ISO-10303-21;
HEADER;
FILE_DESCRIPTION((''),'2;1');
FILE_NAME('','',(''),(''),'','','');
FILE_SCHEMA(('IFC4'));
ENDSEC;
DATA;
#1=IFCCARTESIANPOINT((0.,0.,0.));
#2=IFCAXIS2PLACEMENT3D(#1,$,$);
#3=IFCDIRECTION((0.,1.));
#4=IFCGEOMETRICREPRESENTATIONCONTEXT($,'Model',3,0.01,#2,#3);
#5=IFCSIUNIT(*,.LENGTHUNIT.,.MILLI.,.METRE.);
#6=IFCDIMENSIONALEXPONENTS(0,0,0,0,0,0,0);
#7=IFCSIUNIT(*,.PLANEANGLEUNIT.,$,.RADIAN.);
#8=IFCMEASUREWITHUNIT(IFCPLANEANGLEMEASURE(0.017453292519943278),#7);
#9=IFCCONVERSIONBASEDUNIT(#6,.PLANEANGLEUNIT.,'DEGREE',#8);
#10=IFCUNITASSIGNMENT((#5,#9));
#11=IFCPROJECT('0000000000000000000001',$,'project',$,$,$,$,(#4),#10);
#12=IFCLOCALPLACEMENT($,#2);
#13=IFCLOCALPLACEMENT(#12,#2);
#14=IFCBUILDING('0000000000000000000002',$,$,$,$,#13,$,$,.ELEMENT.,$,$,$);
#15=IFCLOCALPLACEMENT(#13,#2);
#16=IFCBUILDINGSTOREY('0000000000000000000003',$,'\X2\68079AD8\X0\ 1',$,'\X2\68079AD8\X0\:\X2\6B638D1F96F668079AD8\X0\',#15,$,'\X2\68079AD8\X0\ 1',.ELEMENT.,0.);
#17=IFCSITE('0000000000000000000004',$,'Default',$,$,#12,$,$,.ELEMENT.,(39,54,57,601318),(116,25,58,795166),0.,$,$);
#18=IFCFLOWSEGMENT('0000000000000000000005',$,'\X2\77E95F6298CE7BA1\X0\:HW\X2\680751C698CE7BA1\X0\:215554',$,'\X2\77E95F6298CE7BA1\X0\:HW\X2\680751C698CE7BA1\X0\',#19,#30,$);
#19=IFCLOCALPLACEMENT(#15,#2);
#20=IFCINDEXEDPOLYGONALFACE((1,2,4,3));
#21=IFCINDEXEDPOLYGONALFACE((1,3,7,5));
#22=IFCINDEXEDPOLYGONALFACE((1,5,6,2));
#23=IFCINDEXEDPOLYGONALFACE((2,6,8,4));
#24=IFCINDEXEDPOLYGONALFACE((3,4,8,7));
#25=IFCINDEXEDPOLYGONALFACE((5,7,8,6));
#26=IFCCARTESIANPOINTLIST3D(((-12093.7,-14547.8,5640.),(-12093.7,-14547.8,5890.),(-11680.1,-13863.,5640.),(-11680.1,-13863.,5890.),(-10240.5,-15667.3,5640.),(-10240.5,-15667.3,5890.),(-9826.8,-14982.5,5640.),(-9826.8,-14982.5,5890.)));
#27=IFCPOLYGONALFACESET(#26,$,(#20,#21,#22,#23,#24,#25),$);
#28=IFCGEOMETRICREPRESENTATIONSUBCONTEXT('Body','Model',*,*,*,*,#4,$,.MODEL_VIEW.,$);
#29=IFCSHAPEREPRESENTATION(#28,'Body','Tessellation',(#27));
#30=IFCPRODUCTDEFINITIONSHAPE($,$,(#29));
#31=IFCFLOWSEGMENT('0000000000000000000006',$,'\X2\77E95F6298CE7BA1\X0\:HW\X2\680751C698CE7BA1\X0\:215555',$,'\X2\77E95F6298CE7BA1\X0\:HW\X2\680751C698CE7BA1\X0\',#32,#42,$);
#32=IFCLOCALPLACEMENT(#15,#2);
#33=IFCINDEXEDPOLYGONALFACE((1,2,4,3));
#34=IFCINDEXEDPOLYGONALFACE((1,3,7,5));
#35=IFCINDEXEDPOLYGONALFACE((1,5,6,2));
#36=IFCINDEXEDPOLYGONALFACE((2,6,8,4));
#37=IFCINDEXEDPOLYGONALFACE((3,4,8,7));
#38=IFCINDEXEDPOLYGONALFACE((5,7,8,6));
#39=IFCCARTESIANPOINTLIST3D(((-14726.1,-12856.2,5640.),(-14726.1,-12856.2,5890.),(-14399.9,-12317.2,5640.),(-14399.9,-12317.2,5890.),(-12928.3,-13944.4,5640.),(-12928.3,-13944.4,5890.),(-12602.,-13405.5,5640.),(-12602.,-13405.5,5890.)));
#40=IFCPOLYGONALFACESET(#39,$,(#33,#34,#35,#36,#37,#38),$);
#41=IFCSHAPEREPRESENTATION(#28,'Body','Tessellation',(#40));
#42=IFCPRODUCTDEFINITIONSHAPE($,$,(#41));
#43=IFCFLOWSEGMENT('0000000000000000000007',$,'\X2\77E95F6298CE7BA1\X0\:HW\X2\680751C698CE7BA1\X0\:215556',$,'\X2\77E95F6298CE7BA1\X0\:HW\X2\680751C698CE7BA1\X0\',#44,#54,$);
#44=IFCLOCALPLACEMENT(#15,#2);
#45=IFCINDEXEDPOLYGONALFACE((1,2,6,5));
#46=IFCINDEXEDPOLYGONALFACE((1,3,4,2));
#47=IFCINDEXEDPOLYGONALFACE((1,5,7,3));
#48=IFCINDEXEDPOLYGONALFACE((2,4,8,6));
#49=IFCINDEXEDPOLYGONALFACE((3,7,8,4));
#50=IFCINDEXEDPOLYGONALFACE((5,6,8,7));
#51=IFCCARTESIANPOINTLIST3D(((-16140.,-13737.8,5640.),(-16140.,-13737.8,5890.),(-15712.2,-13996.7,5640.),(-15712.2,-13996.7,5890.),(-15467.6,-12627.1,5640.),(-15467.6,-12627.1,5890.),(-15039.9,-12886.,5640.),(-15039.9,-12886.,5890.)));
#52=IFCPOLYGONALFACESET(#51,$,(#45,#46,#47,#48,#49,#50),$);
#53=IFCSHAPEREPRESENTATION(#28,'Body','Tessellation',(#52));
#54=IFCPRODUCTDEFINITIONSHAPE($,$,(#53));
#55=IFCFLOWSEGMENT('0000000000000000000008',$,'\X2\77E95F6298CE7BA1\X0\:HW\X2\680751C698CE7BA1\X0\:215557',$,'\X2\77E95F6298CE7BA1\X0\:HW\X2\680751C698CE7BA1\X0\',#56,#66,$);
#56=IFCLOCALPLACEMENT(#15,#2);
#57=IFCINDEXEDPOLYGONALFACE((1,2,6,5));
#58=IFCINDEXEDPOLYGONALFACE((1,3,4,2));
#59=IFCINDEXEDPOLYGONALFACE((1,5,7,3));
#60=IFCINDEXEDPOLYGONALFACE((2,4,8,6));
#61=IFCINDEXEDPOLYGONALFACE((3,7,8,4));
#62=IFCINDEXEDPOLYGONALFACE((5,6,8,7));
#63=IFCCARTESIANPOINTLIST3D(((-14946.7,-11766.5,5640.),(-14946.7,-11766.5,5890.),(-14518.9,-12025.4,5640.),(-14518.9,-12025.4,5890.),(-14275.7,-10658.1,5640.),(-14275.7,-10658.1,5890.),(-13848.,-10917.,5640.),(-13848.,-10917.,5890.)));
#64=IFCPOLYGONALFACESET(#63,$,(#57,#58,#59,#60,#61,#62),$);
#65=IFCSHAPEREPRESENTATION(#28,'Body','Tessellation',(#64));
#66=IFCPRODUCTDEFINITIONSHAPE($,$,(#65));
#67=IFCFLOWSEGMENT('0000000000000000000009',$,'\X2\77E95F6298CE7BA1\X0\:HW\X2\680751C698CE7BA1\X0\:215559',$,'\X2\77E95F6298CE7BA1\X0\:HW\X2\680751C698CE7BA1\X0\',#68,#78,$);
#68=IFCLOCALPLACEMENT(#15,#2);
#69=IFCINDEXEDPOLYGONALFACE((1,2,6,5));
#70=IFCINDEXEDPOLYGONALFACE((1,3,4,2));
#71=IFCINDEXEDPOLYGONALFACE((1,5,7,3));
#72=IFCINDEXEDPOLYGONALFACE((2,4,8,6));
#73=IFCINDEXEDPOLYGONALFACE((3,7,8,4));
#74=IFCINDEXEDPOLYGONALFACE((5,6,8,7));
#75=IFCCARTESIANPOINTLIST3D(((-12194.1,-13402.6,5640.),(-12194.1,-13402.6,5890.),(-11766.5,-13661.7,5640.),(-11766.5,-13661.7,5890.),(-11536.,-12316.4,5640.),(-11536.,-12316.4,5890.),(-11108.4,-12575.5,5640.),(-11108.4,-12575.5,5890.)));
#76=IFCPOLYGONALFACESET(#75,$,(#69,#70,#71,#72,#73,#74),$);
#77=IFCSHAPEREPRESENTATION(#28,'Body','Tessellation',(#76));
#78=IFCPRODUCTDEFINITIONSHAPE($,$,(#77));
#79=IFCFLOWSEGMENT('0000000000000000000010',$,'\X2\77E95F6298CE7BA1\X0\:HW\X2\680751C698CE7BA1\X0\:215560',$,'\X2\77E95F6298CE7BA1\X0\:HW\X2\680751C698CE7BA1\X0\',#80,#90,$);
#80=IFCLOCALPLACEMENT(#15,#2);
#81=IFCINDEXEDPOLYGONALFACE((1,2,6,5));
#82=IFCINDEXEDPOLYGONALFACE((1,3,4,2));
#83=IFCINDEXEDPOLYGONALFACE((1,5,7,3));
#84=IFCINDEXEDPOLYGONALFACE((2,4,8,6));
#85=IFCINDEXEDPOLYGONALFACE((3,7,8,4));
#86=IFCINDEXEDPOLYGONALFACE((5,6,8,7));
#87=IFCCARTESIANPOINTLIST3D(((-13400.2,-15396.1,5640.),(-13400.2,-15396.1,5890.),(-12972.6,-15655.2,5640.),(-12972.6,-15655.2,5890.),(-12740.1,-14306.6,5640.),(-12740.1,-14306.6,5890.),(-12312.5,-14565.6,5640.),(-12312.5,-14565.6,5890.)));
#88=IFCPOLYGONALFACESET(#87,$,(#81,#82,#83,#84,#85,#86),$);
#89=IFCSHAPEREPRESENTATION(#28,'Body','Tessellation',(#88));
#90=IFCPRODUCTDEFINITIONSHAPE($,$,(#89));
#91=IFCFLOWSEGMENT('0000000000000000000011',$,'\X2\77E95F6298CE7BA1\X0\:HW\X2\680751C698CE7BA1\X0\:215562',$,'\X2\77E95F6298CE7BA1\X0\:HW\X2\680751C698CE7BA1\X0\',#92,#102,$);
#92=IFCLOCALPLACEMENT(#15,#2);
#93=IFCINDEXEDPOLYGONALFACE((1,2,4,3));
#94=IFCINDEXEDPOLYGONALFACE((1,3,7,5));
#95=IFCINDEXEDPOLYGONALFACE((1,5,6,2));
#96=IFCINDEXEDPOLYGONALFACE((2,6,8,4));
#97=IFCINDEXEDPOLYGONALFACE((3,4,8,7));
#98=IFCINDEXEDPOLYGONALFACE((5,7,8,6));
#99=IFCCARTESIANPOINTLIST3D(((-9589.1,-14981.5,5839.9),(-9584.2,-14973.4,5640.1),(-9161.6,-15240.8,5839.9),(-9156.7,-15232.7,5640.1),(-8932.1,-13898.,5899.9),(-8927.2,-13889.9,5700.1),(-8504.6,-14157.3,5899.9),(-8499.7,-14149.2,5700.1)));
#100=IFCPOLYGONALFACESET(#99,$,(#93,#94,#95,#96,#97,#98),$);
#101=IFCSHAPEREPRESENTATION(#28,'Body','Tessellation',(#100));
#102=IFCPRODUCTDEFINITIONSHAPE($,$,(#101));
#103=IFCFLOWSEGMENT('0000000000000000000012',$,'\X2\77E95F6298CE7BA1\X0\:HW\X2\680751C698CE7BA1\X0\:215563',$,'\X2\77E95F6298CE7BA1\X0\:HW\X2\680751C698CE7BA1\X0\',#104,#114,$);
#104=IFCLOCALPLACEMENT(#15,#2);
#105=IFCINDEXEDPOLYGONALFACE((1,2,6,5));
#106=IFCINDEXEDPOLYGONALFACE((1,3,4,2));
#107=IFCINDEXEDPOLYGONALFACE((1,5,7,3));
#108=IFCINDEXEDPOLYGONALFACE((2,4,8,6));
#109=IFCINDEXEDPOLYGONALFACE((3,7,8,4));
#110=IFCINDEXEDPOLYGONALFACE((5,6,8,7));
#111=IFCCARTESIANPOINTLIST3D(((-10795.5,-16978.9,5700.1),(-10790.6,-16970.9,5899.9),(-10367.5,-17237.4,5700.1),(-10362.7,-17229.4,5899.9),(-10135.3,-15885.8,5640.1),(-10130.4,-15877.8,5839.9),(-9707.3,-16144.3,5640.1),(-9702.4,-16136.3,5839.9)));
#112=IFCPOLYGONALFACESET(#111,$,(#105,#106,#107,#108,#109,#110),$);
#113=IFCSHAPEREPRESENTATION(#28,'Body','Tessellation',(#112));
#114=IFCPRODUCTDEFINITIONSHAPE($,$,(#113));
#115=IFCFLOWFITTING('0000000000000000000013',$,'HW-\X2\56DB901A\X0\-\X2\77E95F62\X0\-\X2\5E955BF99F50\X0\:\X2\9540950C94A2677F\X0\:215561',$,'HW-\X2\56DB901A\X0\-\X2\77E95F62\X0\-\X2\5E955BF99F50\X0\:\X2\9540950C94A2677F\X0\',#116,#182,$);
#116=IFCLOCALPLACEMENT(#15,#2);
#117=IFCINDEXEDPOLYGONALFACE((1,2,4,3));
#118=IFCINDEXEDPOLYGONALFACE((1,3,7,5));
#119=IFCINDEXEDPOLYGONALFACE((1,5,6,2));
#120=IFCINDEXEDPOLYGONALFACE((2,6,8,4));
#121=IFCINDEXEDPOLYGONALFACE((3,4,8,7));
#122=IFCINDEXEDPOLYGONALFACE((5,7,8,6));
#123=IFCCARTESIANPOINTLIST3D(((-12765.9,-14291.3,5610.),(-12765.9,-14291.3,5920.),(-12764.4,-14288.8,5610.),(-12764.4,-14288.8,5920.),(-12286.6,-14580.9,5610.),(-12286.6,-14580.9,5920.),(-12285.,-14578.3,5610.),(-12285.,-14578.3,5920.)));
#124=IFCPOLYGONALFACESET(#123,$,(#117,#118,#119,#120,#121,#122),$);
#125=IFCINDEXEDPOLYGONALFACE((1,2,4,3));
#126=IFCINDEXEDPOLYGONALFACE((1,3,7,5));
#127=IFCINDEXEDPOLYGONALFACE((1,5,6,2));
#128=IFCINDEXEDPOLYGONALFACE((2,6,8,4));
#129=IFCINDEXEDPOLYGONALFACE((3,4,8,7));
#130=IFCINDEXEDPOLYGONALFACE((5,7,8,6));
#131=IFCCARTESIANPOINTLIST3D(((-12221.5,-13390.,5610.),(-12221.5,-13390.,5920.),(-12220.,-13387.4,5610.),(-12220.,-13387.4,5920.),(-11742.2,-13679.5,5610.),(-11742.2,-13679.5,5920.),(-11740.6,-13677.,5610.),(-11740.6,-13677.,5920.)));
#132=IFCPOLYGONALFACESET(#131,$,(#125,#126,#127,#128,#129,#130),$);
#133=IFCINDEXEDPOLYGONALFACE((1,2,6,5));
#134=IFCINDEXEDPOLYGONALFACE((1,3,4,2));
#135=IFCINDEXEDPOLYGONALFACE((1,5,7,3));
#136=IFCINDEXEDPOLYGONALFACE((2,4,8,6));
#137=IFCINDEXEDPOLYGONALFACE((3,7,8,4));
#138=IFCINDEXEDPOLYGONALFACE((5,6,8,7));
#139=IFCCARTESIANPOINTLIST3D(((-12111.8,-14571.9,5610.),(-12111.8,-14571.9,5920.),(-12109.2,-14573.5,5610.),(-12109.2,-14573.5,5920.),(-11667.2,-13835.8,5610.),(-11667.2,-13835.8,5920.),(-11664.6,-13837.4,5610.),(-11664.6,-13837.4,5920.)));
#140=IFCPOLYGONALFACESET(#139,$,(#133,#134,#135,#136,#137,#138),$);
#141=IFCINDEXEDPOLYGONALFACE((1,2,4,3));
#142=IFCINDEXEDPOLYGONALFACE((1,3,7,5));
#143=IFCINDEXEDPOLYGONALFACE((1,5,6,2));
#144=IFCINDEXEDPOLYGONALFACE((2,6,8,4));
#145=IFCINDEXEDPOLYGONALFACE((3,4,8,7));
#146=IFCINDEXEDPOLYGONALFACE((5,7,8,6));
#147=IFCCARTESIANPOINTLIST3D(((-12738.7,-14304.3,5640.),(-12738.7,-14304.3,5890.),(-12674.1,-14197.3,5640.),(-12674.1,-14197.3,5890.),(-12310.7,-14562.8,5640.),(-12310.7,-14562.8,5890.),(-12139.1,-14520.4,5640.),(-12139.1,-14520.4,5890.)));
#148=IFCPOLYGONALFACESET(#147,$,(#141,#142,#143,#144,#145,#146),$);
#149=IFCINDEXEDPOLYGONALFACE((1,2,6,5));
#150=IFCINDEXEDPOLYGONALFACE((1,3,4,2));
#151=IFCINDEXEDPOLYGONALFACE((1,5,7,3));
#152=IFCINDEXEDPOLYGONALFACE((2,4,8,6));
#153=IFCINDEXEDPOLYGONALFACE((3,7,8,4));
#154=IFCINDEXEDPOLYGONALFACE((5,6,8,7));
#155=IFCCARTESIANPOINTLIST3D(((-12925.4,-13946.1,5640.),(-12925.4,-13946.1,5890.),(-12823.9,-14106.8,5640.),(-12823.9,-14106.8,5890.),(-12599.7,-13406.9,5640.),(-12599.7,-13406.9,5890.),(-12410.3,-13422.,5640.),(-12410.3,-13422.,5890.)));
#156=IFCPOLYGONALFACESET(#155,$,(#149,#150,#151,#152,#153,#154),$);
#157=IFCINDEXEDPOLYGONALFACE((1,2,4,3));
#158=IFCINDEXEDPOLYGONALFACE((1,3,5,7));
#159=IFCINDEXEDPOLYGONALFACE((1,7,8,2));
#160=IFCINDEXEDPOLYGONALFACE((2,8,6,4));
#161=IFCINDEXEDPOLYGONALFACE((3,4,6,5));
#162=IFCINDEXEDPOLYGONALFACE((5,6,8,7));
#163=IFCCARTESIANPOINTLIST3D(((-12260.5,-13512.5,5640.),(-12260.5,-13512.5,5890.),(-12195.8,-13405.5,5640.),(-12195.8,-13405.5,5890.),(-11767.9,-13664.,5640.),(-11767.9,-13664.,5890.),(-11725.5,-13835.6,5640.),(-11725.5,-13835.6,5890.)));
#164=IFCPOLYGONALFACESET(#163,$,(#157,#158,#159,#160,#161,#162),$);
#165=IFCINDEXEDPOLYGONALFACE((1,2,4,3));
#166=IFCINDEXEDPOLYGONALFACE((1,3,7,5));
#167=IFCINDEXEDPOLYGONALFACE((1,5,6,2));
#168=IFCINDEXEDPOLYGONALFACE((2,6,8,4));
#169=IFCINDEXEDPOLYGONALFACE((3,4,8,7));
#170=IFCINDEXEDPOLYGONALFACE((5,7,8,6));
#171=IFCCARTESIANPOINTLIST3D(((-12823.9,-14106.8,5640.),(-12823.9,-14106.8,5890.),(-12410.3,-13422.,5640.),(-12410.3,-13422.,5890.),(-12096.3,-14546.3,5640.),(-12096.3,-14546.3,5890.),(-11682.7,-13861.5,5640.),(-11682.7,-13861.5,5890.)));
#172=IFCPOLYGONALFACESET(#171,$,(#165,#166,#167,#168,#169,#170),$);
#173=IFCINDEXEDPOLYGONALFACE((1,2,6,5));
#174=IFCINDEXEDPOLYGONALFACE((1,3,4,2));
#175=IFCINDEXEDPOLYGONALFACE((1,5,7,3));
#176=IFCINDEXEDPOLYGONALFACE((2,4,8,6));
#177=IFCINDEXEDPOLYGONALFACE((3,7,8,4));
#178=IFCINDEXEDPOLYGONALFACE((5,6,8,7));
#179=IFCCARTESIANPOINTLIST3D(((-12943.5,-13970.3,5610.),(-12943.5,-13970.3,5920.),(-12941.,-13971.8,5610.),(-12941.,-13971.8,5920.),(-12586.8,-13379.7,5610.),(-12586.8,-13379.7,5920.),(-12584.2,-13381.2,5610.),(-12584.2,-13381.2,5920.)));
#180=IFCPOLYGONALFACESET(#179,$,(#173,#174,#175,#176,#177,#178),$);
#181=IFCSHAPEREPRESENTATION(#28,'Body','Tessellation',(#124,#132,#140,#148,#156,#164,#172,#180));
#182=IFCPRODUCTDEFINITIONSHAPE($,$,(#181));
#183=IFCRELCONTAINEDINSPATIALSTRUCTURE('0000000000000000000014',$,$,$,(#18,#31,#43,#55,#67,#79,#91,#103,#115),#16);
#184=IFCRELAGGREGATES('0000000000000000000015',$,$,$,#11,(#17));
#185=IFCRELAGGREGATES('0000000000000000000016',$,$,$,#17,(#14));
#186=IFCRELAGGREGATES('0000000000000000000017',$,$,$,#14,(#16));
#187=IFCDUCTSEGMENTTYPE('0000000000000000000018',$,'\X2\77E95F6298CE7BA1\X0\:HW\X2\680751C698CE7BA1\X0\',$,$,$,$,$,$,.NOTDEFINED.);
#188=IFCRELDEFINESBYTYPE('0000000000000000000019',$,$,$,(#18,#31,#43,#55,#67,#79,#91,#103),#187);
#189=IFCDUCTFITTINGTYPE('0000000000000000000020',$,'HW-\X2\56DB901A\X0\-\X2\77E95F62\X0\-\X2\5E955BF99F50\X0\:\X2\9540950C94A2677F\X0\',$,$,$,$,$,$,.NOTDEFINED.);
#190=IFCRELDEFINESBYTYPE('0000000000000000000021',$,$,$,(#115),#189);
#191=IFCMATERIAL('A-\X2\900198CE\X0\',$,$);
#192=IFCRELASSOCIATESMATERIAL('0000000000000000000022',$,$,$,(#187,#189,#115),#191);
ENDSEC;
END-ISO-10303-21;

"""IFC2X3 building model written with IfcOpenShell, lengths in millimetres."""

from ifc_helpers import new_model, entity, si_unit, converted_unit, direction, frame, frame_2d, origin, origin_2d_with_axis, place, context, subcontext, project, spatial, polyline, rectangle, outline, extrude, source, transform, mapped, material, type_object, type_shapes, element, save


model = new_model("IFC2X3")

# Units and contexts
model_context = context("Model", 3, precision=0.01, world=origin(), true_north=direction((0.0, 1.0)))
body_context = subcontext(model_context, "Body", "Model", "MODEL_VIEW")
ifc_project = project(units=[si_unit("LENGTHUNIT", "METRE", prefix="MILLI"), converted_unit("PLANEANGLEUNIT", "DEGREE", entity("IfcPlaneAngleMeasure", 0.017453292519943278), si_unit("PLANEANGLEUNIT", "RADIAN"), dimensions=[0, 0, 0, 0, 0, 0, 0])], contexts=[model_context])

# Site, building, storey
site_placement = place(None, origin())
site = spatial("IfcSite", under=ifc_project, at=site_placement, Name="Default", CompositionType="ELEMENT", RefLatitude=(39, 54, 57, 601318), RefLongitude=(116, 25, 58, 795166), RefElevation=0.0)
building_placement = place(site_placement, origin())
building = spatial("IfcBuilding", under=site, at=building_placement, CompositionType="ELEMENT")
storey_placement = place(building_placement, origin())
storey = spatial("IfcBuildingStorey", under=building, at=storey_placement, Name="标高 1", ObjectType="标高:正负零标高", LongName="标高 1", CompositionType="ELEMENT", Elevation=0.0)

# Flow segments
ifc_material = material(Name="A-送风")
duct_segment_type = type_object("IfcDuctSegmentType", Name="矩形风管:HW标准风管", PredefinedType="NOTDEFINED", material=ifc_material)
flow_segment_1_placement = place(storey_placement, origin())
element("IfcFlowSegment", 1, at=flow_segment_1_placement, inside=storey, type_object=duct_segment_type, Name="矩形风管:HW标准风管:215554", ObjectType="矩形风管:HW标准风管", context=body_context, shape_type="SweptSolid", body=[
    extrude(rectangle(XDim=2165.1, YDim=800.0, at=origin_2d_with_axis()), frame((-10960.3, -14765.1, 5640.0), z_axis=(0.0, 0.0, 1.0), x_axis=(-0.855967, 0.517031, 0.0)), (0.0, 0.0, 1.0), 250.0),
])
flow_segment_2_placement = place(storey_placement, origin())
element("IfcFlowSegment", 2, at=flow_segment_2_placement, inside=storey, type_object=duct_segment_type, Name="矩形风管:HW标准风管:215555", ObjectType="矩形风管:HW标准风管", context=body_context, shape_type="SweptSolid", body=[
    extrude(rectangle(XDim=2101.5, YDim=630.0, at=origin_2d_with_axis()), frame((-13664.1, -13130.8, 5640.0), z_axis=(0.0, 0.0, 1.0), x_axis=(-0.855477, 0.517841, 0.0)), (0.0, 0.0, 1.0), 250.0),
])
flow_segment_3_placement = place(storey_placement, origin())
element("IfcFlowSegment", 3, at=flow_segment_3_placement, inside=storey, type_object=duct_segment_type, Name="矩形风管:HW标准风管:215556", ObjectType="矩形风管:HW标准风管", context=body_context, shape_type="SweptSolid", body=[
    extrude(rectangle(XDim=1298.4, YDim=500.0, at=origin_2d_with_axis()), frame((-15589.9, -13311.9, 5640.0), z_axis=(0.0, 0.0, 1.0), x_axis=(0.517838, 0.855478, 0.0)), (0.0, 0.0, 1.0), 250.0),
])
flow_segment_4_placement = place(storey_placement, origin())
element("IfcFlowSegment", 4, at=flow_segment_4_placement, inside=storey, type_object=duct_segment_type, Name="矩形风管:HW标准风管:215557", ObjectType="矩形风管:HW标准风管", context=body_context, shape_type="SweptSolid", body=[
    extrude(rectangle(XDim=1295.6, YDim=500.0, at=frame_2d((0.0, 0.0), x_axis=(1.0, 0.0))), frame((-14397.3, -11341.7, 5640.0), z_axis=(0.0, 0.0, 1.0), x_axis=(0.517843, 0.855476, 0.0)), (0.0, 0.0, 1.0), 250.0),
])
flow_segment_5_placement = place(storey_placement, origin())
element("IfcFlowSegment", 5, at=flow_segment_5_placement, inside=storey, type_object=duct_segment_type, Name="矩形风管:HW标准风管:215559", ObjectType="矩形风管:HW标准风管", context=body_context, shape_type="SweptSolid", body=[
    extrude(rectangle(XDim=1270.0, YDim=500.0, at=frame_2d((0.0, 0.0), x_axis=(1.0, 0.0))), frame((-11651.2, -12989.1, 5640.0), z_axis=(0.0, 0.0, 1.0), x_axis=(-0.518182, -0.85527, 0.0)), (0.0, 0.0, 1.0), 250.0),
])
flow_segment_6_placement = place(storey_placement, origin())
element("IfcFlowSegment", 6, at=flow_segment_6_placement, inside=storey, type_object=duct_segment_type, Name="矩形风管:HW标准风管:215560", ObjectType="矩形风管:HW标准风管", context=body_context, shape_type="SweptSolid", body=[
    extrude(rectangle(XDim=1274.0, YDim=500.0, at=origin_2d_with_axis()), frame((-12856.3, -14980.9, 5640.0), z_axis=(0.0, 0.0, 1.0), x_axis=(0.518177, 0.855274, 0.0)), (0.0, 0.0, 1.0), 250.0),
])
flow_segment_7_placement = place(storey_placement, origin())
element("IfcFlowSegment", 7, at=flow_segment_7_placement, inside=storey, type_object=duct_segment_type, Name="矩形风管:HW标准风管:215562", ObjectType="矩形风管:HW标准风管", context=body_context, shape_type="SweptSolid", body=[
    extrude(rectangle(XDim=200.0, YDim=500.0, at=frame_2d((0.0, 0.0), x_axis=(1.0, 0.0))), frame((-9372.9, -15107.1, 5740.0), z_axis=(0.517949, 0.854103, 0.047298), x_axis=(-0.024525, -0.040443, 0.998881)), (0.0, 0.0, 1.0), 1268.6),
])
flow_segment_8_placement = place(storey_placement, origin())
element("IfcFlowSegment", 8, at=flow_segment_8_placement, inside=storey, type_object=duct_segment_type, Name="矩形风管:HW标准风管:215563", ObjectType="矩形风管:HW标准风管", context=body_context, shape_type="SweptSolid", body=[
    extrude(rectangle(XDim=200.0, YDim=500.0, at=frame_2d((0.0, 0.0), x_axis=(0.0, 1.0))), frame((-10579.1, -17104.1, 5800.0), z_axis=(0.51643, 0.855042, -0.046933), x_axis=(-0.855985, 0.517, 0.0)), (0.0, 0.0, 1.0), 1278.4),
])

# Flow fitting
duct_fitting_type_1 = type_object("IfcDuctFittingType", Name="HW-四通-矩形-底对齐:镀锌钢板", PredefinedType="NOTDEFINED", material=ifc_material)
shared_shape_1 = source(origin(), body_context, "Body", "SweptSolid", [
    extrude(rectangle(XDim=560.0, YDim=3.0, at=origin_2d_with_axis()), frame((0.0, 526.5, -155.0), z_axis=(0.0, 0.0, 1.0), x_axis=(-1.0, 0.0, 0.0)), (0.0, 0.0, 1.0), 310.0),
    extrude(rectangle(XDim=560.0, YDim=3.0, at=frame_2d((0.0, 0.0), x_axis=(1.0, 0.0))), frame((0.0, -526.5, -155.0), z_axis=(0.0, 0.0, 1.0), x_axis=(-1.0, 0.0, 0.0)), (0.0, 0.0, 1.0), 310.0),
    extrude(rectangle(XDim=860.0, YDim=3.0, at=frame_2d((0.0, 0.0), x_axis=(1.0, 0.0))), frame((-426.5, 0.0, -155.0), z_axis=(0.0, 0.0, 1.0), x_axis=(0.0, 1.0, 0.0)), (0.0, 0.0, 1.0), 310.0),
    extrude(outline(polyline([(110.5, -198.9), (287.3, -198.9), (-154.7, 243.1), (-243.1, 154.7), (110.5, -198.9)])), frame((-31.2, 462.5, -125.0), z_axis=(0.0, 0.0, 1.0), x_axis=(-0.707107, -0.707107, 0.0)), (0.0, 0.0, 1.0), 250.0),
    extrude(outline(polyline([(64.8, -319.8), (254.9, -319.8), (-102.9, 395.8), (-216.9, 243.7), (64.8, -319.8)])), frame((510.0, 0.0, -125.0), z_axis=(0.0, 0.0, 1.0), x_axis=(-0.894427, 0.447214, 0.0)), (0.0, 0.0, 1.0), 250.0),
    extrude(outline(polyline([(-62.5, -281.2), (62.5, -281.2), (62.5, 343.8), (-62.5, 218.7), (-62.5, -281.2)])), frame((-31.3, -462.5, -125.0), z_axis=(0.0, 0.0, 1.0), x_axis=(0.0, 1.0, 0.0)), (0.0, 0.0, 1.0), 250.0),
    extrude(rectangle(XDim=850.0, YDim=800.0, at=origin_2d_with_axis()), frame((0.0, 0.0, -125.0), z_axis=(0.0, 0.0, 1.0), x_axis=(-1.0, 0.0, 0.0)), (0.0, 0.0, 1.0), 250.0),
    extrude(rectangle(XDim=690.0, YDim=3.0, at=frame_2d((0.0, 0.0), x_axis=(1.0, 0.0))), frame((596.5, 0.0, -155.0), z_axis=(0.0, 0.0, 1.0), x_axis=(0.0, 1.0, 0.0)), (0.0, 0.0, 1.0), 310.0),
])
type_shapes(duct_fitting_type_1, [shared_shape_1])
flow_fitting_1_placement = place(storey_placement, frame((-12253.3, -13984.1, 5765.0), z_axis=(0.0, 0.0, 1.0), x_axis=(-0.855971, 0.517024, 0.0)))
element("IfcFlowFitting", 9, at=flow_fitting_1_placement, inside=storey, type_object=duct_fitting_type_1, material=ifc_material, Name="HW-四通-矩形-底对齐:镀锌钢板:215561", ObjectType="HW-四通-矩形-底对齐:镀锌钢板", context=body_context, shape_type="MappedRepresentation", body=[
    mapped(shared_shape_1, transform((0.0, 0.0, 0.0), scale=1.0)),
])

save(model, "model.ifc")
